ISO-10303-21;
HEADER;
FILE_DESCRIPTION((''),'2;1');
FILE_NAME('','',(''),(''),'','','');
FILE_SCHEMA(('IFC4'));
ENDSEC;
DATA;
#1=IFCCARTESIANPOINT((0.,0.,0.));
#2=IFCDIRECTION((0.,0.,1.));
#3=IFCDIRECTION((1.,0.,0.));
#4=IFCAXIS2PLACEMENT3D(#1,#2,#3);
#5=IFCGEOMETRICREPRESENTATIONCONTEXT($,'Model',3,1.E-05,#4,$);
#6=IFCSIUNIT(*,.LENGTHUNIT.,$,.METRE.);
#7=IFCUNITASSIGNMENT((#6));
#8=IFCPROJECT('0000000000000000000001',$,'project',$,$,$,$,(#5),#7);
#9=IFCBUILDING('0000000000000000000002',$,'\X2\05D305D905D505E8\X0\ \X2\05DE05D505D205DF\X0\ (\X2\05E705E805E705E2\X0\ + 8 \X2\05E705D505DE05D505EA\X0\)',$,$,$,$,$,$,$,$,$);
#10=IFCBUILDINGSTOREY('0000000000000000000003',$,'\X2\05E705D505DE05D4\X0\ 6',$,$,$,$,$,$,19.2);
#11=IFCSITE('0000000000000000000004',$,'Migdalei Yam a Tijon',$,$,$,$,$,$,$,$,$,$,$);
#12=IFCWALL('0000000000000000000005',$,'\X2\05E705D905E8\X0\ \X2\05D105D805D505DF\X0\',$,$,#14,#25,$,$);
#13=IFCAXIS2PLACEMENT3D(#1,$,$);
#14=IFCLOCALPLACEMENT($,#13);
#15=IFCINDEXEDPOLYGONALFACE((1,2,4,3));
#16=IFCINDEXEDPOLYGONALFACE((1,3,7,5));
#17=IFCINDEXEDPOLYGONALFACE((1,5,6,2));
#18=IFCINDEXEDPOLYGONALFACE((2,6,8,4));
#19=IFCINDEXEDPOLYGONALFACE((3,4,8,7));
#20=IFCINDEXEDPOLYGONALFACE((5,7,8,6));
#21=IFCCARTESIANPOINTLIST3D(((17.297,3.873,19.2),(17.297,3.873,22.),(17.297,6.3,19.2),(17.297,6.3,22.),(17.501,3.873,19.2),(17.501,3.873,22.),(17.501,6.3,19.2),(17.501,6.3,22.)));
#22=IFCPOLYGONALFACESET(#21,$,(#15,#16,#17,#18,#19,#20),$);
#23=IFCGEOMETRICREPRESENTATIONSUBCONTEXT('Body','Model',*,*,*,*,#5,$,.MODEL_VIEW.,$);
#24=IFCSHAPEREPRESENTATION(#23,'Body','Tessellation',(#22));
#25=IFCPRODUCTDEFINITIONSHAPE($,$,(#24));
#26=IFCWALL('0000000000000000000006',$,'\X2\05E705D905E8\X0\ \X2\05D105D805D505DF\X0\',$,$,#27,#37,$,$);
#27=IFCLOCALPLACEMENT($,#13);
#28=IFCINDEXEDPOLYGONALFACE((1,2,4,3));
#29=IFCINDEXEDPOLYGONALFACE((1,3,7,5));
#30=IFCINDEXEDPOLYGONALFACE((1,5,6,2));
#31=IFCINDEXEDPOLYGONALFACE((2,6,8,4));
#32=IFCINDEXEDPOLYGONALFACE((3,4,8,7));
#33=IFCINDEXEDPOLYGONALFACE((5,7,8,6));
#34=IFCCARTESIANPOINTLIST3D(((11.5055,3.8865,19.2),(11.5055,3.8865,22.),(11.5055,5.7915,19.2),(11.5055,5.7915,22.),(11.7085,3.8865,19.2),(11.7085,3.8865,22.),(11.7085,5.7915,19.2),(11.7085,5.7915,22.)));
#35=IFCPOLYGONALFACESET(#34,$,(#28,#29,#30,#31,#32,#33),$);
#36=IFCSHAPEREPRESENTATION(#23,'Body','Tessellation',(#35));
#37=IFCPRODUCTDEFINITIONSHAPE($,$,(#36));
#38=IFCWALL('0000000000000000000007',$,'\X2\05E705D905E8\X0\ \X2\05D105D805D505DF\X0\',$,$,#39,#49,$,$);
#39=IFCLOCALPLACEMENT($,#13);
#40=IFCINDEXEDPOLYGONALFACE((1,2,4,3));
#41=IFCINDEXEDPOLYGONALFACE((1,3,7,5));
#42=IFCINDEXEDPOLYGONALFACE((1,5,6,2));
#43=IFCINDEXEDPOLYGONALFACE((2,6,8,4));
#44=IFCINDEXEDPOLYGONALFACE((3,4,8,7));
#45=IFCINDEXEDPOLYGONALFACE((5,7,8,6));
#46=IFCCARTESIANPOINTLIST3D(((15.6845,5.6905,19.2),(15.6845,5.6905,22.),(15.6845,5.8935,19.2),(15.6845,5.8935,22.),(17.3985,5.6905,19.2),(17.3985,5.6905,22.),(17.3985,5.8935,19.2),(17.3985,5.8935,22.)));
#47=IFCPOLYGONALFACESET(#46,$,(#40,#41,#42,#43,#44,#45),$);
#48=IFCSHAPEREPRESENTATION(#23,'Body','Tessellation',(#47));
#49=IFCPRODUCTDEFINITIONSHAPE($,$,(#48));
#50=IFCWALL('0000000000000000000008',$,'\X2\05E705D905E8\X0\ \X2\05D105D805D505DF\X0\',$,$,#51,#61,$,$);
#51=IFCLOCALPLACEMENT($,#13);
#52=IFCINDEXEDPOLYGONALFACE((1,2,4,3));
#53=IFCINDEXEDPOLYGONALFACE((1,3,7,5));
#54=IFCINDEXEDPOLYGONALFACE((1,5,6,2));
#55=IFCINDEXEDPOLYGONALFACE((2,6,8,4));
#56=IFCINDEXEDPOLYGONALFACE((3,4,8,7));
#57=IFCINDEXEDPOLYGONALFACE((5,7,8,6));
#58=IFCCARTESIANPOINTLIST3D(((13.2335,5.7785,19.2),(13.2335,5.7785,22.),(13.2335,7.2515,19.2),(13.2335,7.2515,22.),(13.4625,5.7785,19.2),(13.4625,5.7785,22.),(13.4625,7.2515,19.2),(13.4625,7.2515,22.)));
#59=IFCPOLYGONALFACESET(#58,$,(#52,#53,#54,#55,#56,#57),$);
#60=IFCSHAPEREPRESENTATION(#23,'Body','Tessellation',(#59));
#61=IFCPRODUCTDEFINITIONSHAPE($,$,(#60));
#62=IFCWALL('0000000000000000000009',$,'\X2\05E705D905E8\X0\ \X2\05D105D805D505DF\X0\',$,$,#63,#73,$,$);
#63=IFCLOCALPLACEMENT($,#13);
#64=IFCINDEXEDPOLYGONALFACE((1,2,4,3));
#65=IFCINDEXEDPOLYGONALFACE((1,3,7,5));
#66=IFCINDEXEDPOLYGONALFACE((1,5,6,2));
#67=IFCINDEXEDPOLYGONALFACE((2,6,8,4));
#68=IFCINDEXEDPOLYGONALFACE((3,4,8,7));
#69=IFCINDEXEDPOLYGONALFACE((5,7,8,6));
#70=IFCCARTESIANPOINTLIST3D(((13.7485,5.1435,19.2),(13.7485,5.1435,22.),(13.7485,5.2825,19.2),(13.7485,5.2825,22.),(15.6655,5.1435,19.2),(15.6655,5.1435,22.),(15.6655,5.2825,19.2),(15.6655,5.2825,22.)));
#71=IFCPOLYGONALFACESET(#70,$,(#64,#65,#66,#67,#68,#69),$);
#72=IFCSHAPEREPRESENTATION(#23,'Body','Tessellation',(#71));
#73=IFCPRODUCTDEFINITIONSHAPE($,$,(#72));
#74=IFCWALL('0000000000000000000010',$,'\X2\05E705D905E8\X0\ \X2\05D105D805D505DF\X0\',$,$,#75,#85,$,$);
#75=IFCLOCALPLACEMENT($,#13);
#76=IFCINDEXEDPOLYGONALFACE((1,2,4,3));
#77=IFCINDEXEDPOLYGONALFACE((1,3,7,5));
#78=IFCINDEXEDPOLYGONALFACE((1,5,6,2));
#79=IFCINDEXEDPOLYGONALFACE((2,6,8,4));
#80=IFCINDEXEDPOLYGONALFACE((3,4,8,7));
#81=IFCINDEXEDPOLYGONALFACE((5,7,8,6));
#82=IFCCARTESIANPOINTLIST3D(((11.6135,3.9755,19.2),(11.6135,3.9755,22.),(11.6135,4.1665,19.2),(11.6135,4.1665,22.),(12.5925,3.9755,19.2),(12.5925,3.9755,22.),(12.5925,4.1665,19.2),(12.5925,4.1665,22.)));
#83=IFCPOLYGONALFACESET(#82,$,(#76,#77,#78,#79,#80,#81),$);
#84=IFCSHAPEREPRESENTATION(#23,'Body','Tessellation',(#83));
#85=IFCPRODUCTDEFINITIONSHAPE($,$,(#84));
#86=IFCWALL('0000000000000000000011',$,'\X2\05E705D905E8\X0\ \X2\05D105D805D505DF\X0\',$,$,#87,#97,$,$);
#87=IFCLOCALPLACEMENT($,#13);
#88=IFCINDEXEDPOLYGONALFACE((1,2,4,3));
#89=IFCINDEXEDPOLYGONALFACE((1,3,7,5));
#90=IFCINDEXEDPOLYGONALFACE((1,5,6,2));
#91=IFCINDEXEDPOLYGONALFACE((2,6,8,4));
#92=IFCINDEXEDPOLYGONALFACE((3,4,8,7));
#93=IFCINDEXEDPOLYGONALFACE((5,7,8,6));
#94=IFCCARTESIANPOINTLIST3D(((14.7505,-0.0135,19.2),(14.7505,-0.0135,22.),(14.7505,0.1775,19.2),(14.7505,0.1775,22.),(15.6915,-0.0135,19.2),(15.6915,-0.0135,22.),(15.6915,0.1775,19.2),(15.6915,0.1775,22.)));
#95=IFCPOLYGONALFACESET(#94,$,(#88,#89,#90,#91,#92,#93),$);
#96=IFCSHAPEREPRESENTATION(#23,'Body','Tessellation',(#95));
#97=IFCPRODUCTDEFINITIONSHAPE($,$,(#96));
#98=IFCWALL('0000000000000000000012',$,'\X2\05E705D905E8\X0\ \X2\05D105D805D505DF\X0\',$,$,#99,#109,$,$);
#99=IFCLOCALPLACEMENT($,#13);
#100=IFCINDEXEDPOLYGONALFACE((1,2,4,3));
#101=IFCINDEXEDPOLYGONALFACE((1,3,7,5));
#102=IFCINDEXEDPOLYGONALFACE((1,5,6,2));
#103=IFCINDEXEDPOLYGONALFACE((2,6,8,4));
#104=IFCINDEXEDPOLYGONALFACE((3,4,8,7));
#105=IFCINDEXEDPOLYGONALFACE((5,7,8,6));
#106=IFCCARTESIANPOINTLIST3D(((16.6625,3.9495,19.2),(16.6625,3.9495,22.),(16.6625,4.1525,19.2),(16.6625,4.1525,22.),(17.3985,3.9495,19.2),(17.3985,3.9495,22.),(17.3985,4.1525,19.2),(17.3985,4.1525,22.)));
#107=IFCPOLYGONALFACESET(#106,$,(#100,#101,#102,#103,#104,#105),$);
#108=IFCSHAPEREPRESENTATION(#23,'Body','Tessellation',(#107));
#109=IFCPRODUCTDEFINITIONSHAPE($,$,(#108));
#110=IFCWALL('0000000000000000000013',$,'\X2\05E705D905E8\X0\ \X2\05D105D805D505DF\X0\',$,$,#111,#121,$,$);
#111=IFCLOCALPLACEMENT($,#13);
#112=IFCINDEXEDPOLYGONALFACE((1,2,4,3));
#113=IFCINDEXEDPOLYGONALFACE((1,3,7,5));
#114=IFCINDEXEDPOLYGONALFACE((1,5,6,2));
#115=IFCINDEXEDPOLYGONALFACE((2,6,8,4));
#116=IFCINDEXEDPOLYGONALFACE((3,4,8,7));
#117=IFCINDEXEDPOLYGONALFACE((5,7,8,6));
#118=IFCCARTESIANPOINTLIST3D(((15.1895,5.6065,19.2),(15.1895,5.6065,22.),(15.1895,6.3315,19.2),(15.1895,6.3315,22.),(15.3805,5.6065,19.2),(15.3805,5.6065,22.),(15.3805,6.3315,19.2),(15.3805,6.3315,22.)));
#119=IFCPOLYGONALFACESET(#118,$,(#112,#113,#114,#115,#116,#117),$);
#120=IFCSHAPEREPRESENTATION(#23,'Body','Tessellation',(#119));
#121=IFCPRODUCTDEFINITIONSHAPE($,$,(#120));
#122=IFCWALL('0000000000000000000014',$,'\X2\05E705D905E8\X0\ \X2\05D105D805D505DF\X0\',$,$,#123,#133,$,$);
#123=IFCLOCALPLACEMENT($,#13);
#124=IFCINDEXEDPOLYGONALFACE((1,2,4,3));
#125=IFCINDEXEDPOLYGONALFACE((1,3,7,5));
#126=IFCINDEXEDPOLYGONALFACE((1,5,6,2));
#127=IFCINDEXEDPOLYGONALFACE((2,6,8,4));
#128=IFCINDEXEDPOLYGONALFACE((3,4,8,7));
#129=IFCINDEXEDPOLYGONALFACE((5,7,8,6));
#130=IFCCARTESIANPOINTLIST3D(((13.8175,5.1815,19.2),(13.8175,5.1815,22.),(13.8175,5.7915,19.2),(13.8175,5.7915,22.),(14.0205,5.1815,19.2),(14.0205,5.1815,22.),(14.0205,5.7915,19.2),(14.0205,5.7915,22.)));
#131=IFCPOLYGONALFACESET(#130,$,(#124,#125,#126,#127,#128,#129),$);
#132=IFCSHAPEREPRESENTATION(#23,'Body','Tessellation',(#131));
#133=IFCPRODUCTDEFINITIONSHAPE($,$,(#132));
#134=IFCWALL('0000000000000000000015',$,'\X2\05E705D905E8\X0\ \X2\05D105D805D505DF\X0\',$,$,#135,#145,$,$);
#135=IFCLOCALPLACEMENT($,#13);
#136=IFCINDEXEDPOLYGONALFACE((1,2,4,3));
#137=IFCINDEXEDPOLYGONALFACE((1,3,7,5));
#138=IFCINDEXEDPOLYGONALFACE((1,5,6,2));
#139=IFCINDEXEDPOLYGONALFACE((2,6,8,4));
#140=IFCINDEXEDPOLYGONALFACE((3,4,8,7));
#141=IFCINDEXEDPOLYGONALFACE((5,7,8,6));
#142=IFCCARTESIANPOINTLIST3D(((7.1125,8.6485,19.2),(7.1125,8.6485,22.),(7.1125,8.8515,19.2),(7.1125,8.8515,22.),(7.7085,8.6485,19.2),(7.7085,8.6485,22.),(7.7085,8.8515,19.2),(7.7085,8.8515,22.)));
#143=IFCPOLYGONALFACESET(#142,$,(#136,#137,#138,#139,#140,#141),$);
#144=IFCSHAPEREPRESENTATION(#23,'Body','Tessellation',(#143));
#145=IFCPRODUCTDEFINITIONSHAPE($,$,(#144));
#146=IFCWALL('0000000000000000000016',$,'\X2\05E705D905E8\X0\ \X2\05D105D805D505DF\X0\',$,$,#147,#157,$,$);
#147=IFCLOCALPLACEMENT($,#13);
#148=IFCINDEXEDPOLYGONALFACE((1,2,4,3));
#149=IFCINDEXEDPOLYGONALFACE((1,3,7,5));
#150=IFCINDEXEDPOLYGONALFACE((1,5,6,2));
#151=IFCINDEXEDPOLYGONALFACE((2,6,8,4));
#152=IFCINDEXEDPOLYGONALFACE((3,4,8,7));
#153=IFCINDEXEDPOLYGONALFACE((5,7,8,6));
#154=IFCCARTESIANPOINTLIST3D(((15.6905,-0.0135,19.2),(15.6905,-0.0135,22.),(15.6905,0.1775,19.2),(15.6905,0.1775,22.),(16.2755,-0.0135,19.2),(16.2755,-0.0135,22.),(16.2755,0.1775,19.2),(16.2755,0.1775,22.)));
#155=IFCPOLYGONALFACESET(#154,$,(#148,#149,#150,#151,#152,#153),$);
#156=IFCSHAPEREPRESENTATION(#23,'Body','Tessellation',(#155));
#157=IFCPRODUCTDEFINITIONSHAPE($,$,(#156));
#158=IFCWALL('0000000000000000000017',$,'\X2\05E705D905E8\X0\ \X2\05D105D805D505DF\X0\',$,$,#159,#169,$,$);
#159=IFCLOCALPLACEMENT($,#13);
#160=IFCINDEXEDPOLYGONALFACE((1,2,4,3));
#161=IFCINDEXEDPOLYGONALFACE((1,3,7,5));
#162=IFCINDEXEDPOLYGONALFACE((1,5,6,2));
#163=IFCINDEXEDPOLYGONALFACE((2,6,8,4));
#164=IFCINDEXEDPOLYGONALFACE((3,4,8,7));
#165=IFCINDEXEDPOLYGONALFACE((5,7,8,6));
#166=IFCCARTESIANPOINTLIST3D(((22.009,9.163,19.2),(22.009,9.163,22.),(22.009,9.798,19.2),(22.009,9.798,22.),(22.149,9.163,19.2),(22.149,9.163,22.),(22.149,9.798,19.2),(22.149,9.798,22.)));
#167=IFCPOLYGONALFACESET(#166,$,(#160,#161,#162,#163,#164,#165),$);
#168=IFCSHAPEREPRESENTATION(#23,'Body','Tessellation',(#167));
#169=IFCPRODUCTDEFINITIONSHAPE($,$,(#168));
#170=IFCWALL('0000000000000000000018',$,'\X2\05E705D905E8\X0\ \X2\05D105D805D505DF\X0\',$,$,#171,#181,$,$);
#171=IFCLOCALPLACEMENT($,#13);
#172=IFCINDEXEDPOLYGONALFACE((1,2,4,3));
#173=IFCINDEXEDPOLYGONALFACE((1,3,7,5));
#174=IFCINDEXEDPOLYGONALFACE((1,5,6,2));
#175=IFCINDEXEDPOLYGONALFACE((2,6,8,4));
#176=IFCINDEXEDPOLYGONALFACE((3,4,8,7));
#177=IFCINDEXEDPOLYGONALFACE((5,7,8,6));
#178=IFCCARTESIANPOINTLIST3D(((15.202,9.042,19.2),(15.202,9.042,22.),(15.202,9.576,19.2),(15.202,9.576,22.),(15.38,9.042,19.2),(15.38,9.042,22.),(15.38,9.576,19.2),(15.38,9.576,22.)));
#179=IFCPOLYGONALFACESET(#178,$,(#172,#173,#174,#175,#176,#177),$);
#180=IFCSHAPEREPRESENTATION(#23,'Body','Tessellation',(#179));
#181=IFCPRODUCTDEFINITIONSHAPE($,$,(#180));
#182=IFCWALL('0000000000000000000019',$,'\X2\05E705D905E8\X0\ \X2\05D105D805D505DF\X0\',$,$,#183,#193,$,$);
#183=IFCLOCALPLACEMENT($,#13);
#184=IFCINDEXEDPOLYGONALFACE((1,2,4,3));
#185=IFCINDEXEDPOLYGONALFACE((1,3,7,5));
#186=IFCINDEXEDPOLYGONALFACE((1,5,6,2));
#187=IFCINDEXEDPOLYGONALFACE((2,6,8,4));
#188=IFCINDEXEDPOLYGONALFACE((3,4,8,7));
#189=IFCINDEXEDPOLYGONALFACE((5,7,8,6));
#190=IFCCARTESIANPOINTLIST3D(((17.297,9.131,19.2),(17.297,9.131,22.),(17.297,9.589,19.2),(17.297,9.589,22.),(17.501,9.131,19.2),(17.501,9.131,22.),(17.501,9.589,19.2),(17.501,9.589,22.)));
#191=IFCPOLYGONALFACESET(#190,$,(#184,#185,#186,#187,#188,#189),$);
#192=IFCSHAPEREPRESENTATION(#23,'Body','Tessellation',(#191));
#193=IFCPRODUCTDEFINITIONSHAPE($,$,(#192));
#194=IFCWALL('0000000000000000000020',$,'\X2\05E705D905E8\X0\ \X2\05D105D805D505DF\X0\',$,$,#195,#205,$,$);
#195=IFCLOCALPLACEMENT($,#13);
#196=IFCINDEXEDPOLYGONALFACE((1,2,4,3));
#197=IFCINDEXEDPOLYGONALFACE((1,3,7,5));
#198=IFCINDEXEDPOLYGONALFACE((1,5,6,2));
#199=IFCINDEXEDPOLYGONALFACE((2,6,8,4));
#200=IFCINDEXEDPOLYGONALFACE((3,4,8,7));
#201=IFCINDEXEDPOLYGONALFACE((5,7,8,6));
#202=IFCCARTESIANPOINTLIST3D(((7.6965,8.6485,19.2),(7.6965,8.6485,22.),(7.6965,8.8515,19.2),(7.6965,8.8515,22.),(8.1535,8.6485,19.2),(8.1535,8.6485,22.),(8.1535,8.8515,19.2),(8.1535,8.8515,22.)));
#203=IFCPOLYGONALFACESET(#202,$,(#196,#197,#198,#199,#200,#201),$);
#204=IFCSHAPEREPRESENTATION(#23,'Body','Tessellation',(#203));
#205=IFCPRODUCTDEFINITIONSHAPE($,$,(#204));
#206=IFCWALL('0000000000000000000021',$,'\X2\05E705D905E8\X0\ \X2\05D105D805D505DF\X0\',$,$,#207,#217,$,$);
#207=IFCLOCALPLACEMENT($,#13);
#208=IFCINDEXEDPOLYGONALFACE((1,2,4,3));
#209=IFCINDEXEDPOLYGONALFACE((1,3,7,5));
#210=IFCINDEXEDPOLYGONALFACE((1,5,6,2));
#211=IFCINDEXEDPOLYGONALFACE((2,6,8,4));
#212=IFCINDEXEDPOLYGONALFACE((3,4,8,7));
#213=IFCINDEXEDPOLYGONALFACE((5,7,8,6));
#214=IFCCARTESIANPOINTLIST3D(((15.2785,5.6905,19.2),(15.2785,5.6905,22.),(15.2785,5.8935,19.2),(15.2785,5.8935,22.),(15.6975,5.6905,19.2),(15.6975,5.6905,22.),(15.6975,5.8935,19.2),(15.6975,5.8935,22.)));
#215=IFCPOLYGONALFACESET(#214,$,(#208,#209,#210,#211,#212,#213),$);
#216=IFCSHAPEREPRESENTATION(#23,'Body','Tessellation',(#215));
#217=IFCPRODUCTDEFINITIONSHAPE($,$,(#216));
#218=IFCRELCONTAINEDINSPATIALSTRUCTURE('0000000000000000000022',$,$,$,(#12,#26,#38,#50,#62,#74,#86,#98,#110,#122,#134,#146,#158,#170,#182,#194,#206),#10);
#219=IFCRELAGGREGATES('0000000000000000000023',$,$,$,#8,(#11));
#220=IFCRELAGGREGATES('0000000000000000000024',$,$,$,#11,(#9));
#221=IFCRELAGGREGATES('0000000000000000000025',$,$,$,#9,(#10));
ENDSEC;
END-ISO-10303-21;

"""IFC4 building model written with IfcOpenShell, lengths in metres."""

from ifc_helpers import new_model, si_unit, frame, origin_with_axes, context, subcontext, project, spatial, line, indexed_curve, outline, extrude, element, save


model = new_model("IFC4")

# Units and contexts
model_context = context("Model", 3, precision=1e-05, world=origin_with_axes())
body_context = subcontext(model_context, "Body", "Model", "MODEL_VIEW")
ifc_project = project(units=[si_unit("LENGTHUNIT", "METRE")], contexts=[model_context])

# Site, building, storey
site = spatial("IfcSite", under=ifc_project, Name="Migdalei Yam a Tijon")
building = spatial("IfcBuilding", under=site, Name="דיור מוגן (קרקע + 8 קומות)")
storey = spatial("IfcBuildingStorey", under=building, Name="קומה 6", Elevation=19.2)

# Walls
element("IfcWall", 1, inside=storey, Name="קיר בטון", context=body_context, shape_type="SweptSolid", body=[
    extrude(outline(indexed_curve([(0.0, 0.0), (0.204, 0.0), (0.204, 2.427), (0.0, 2.427)], segments=[line(1, 2, 3, 4, 1)])), frame((17.297, 3.873, 19.2), z_axis=(0.0, 0.0, 1.0), x_axis=(1.0, 0.0, 0.0)), (0.0, 0.0, 1.0), 2.8),
])
element("IfcWall", 2, inside=storey, Name="קיר בטון", context=body_context, shape_type="SweptSolid", body=[
    extrude(outline(indexed_curve([(0.0, 0.0), (0.203, 0.0), (0.203, 1.905), (0.0, 1.905)], segments=[line(1, 2, 3, 4, 1)])), frame((11.5055, 3.8865, 19.2), z_axis=(0.0, 0.0, 1.0), x_axis=(1.0, 0.0, 0.0)), (0.0, 0.0, 1.0), 2.8),
])
element("IfcWall", 3, inside=storey, Name="קיר בטון", context=body_context, shape_type="SweptSolid", body=[
    extrude(outline(indexed_curve([(0.0, 0.0), (1.714, 0.0), (1.714, 0.203), (0.0, 0.203)], segments=[line(1, 2, 3, 4, 1)])), frame((15.6845, 5.6905, 19.2), z_axis=(0.0, 0.0, 1.0), x_axis=(1.0, 0.0, 0.0)), (0.0, 0.0, 1.0), 2.8),
])
element("IfcWall", 4, inside=storey, Name="קיר בטון", context=body_context, shape_type="SweptSolid", body=[
    extrude(outline(indexed_curve([(0.0, 0.0), (0.229, 0.0), (0.229, 1.473), (0.0, 1.473)], segments=[line(1, 2, 3, 4, 1)])), frame((13.2335, 5.7785, 19.2), z_axis=(0.0, 0.0, 1.0), x_axis=(1.0, 0.0, 0.0)), (0.0, 0.0, 1.0), 2.8),
])
element("IfcWall", 5, inside=storey, Name="קיר בטון", context=body_context, shape_type="SweptSolid", body=[
    extrude(outline(indexed_curve([(0.0, 0.0), (1.917, 0.0), (1.917, 0.139), (0.0, 0.139)], segments=[line(1, 2, 3, 4, 1)])), frame((13.7485, 5.1435, 19.2), z_axis=(0.0, 0.0, 1.0), x_axis=(1.0, 0.0, 0.0)), (0.0, 0.0, 1.0), 2.8),
])
element("IfcWall", 6, inside=storey, Name="קיר בטון", context=body_context, shape_type="SweptSolid", body=[
    extrude(outline(indexed_curve([(0.0, 0.0), (0.979, 0.0), (0.979, 0.191), (0.0, 0.191)], segments=[line(1, 2, 3, 4, 1)])), frame((11.6135, 3.9755, 19.2), z_axis=(0.0, 0.0, 1.0), x_axis=(1.0, 0.0, 0.0)), (0.0, 0.0, 1.0), 2.8),
])
element("IfcWall", 7, inside=storey, Name="קיר בטון", context=body_context, shape_type="SweptSolid", body=[
    extrude(outline(indexed_curve([(0.0, 0.0), (0.941, 0.0), (0.941, 0.191), (0.0, 0.191)], segments=[line(1, 2, 3, 4, 1)])), frame((14.7505, -0.0135, 19.2), z_axis=(0.0, 0.0, 1.0), x_axis=(1.0, 0.0, 0.0)), (0.0, 0.0, 1.0), 2.8),
])
element("IfcWall", 8, inside=storey, Name="קיר בטון", context=body_context, shape_type="SweptSolid", body=[
    extrude(outline(indexed_curve([(0.0, 0.0), (0.736, 0.0), (0.736, 0.203), (0.0, 0.203)], segments=[line(1, 2, 3, 4, 1)])), frame((16.6625, 3.9495, 19.2), z_axis=(0.0, 0.0, 1.0), x_axis=(1.0, 0.0, 0.0)), (0.0, 0.0, 1.0), 2.8),
])
element("IfcWall", 9, inside=storey, Name="קיר בטון", context=body_context, shape_type="SweptSolid", body=[
    extrude(outline(indexed_curve([(0.0, 0.0), (0.191, 0.0), (0.191, 0.725), (0.0, 0.725)], segments=[line(1, 2, 3, 4, 1)])), frame((15.1895, 5.6065, 19.2), z_axis=(0.0, 0.0, 1.0), x_axis=(1.0, 0.0, 0.0)), (0.0, 0.0, 1.0), 2.8),
])
element("IfcWall", 10, inside=storey, Name="קיר בטון", context=body_context, shape_type="SweptSolid", body=[
    extrude(outline(indexed_curve([(0.0, 0.0), (0.203, 0.0), (0.203, 0.61), (0.0, 0.61)], segments=[line(1, 2, 3, 4, 1)])), frame((13.8175, 5.1815, 19.2), z_axis=(0.0, 0.0, 1.0), x_axis=(1.0, 0.0, 0.0)), (0.0, 0.0, 1.0), 2.8),
])
element("IfcWall", 11, inside=storey, Name="קיר בטון", context=body_context, shape_type="SweptSolid", body=[
    extrude(outline(indexed_curve([(0.0, 0.0), (0.596, 0.0), (0.596, 0.203), (0.0, 0.203)], segments=[line(1, 2, 3, 4, 1)])), frame((7.1125, 8.6485, 19.2), z_axis=(0.0, 0.0, 1.0), x_axis=(1.0, 0.0, 0.0)), (0.0, 0.0, 1.0), 2.8),
])
element("IfcWall", 12, inside=storey, Name="קיר בטון", context=body_context, shape_type="SweptSolid", body=[
    extrude(outline(indexed_curve([(0.0, 0.0), (0.585, 0.0), (0.585, 0.191), (0.0, 0.191)], segments=[line(1, 2, 3, 4, 1)])), frame((15.6905, -0.0135, 19.2), z_axis=(0.0, 0.0, 1.0), x_axis=(1.0, 0.0, 0.0)), (0.0, 0.0, 1.0), 2.8),
])
element("IfcWall", 13, inside=storey, Name="קיר בטון", context=body_context, shape_type="SweptSolid", body=[
    extrude(outline(indexed_curve([(0.0, 0.0), (0.14, 0.0), (0.14, 0.635), (0.0, 0.635)], segments=[line(1, 2, 3, 4, 1)])), frame((22.009, 9.163, 19.2), z_axis=(0.0, 0.0, 1.0), x_axis=(1.0, 0.0, 0.0)), (0.0, 0.0, 1.0), 2.8),
])
element("IfcWall", 14, inside=storey, Name="קיר בטון", context=body_context, shape_type="SweptSolid", body=[
    extrude(outline(indexed_curve([(0.0, 0.0), (0.178, 0.0), (0.178, 0.534), (0.0, 0.534)], segments=[line(1, 2, 3, 4, 1)])), frame((15.202, 9.042, 19.2), z_axis=(0.0, 0.0, 1.0), x_axis=(1.0, 0.0, 0.0)), (0.0, 0.0, 1.0), 2.8),
])
element("IfcWall", 15, inside=storey, Name="קיר בטון", context=body_context, shape_type="SweptSolid", body=[
    extrude(outline(indexed_curve([(0.0, 0.0), (0.204, 0.0), (0.204, 0.458), (0.0, 0.458)], segments=[line(1, 2, 3, 4, 1)])), frame((17.297, 9.131, 19.2), z_axis=(0.0, 0.0, 1.0), x_axis=(1.0, 0.0, 0.0)), (0.0, 0.0, 1.0), 2.8),
])
element("IfcWall", 16, inside=storey, Name="קיר בטון", context=body_context, shape_type="SweptSolid", body=[
    extrude(outline(indexed_curve([(0.0, 0.0), (0.457, 0.0), (0.457, 0.203), (0.0, 0.203)], segments=[line(1, 2, 3, 4, 1)])), frame((7.6965, 8.6485, 19.2), z_axis=(0.0, 0.0, 1.0), x_axis=(1.0, 0.0, 0.0)), (0.0, 0.0, 1.0), 2.8),
])
element("IfcWall", 17, inside=storey, Name="קיר בטון", context=body_context, shape_type="SweptSolid", body=[
    extrude(outline(indexed_curve([(0.0, 0.0), (0.419, 0.0), (0.419, 0.203), (0.0, 0.203)], segments=[line(1, 2, 3, 4, 1)])), frame((15.2785, 5.6905, 19.2), z_axis=(0.0, 0.0, 1.0), x_axis=(1.0, 0.0, 0.0)), (0.0, 0.0, 1.0), 2.8),
])

save(model, "model.ifc")
